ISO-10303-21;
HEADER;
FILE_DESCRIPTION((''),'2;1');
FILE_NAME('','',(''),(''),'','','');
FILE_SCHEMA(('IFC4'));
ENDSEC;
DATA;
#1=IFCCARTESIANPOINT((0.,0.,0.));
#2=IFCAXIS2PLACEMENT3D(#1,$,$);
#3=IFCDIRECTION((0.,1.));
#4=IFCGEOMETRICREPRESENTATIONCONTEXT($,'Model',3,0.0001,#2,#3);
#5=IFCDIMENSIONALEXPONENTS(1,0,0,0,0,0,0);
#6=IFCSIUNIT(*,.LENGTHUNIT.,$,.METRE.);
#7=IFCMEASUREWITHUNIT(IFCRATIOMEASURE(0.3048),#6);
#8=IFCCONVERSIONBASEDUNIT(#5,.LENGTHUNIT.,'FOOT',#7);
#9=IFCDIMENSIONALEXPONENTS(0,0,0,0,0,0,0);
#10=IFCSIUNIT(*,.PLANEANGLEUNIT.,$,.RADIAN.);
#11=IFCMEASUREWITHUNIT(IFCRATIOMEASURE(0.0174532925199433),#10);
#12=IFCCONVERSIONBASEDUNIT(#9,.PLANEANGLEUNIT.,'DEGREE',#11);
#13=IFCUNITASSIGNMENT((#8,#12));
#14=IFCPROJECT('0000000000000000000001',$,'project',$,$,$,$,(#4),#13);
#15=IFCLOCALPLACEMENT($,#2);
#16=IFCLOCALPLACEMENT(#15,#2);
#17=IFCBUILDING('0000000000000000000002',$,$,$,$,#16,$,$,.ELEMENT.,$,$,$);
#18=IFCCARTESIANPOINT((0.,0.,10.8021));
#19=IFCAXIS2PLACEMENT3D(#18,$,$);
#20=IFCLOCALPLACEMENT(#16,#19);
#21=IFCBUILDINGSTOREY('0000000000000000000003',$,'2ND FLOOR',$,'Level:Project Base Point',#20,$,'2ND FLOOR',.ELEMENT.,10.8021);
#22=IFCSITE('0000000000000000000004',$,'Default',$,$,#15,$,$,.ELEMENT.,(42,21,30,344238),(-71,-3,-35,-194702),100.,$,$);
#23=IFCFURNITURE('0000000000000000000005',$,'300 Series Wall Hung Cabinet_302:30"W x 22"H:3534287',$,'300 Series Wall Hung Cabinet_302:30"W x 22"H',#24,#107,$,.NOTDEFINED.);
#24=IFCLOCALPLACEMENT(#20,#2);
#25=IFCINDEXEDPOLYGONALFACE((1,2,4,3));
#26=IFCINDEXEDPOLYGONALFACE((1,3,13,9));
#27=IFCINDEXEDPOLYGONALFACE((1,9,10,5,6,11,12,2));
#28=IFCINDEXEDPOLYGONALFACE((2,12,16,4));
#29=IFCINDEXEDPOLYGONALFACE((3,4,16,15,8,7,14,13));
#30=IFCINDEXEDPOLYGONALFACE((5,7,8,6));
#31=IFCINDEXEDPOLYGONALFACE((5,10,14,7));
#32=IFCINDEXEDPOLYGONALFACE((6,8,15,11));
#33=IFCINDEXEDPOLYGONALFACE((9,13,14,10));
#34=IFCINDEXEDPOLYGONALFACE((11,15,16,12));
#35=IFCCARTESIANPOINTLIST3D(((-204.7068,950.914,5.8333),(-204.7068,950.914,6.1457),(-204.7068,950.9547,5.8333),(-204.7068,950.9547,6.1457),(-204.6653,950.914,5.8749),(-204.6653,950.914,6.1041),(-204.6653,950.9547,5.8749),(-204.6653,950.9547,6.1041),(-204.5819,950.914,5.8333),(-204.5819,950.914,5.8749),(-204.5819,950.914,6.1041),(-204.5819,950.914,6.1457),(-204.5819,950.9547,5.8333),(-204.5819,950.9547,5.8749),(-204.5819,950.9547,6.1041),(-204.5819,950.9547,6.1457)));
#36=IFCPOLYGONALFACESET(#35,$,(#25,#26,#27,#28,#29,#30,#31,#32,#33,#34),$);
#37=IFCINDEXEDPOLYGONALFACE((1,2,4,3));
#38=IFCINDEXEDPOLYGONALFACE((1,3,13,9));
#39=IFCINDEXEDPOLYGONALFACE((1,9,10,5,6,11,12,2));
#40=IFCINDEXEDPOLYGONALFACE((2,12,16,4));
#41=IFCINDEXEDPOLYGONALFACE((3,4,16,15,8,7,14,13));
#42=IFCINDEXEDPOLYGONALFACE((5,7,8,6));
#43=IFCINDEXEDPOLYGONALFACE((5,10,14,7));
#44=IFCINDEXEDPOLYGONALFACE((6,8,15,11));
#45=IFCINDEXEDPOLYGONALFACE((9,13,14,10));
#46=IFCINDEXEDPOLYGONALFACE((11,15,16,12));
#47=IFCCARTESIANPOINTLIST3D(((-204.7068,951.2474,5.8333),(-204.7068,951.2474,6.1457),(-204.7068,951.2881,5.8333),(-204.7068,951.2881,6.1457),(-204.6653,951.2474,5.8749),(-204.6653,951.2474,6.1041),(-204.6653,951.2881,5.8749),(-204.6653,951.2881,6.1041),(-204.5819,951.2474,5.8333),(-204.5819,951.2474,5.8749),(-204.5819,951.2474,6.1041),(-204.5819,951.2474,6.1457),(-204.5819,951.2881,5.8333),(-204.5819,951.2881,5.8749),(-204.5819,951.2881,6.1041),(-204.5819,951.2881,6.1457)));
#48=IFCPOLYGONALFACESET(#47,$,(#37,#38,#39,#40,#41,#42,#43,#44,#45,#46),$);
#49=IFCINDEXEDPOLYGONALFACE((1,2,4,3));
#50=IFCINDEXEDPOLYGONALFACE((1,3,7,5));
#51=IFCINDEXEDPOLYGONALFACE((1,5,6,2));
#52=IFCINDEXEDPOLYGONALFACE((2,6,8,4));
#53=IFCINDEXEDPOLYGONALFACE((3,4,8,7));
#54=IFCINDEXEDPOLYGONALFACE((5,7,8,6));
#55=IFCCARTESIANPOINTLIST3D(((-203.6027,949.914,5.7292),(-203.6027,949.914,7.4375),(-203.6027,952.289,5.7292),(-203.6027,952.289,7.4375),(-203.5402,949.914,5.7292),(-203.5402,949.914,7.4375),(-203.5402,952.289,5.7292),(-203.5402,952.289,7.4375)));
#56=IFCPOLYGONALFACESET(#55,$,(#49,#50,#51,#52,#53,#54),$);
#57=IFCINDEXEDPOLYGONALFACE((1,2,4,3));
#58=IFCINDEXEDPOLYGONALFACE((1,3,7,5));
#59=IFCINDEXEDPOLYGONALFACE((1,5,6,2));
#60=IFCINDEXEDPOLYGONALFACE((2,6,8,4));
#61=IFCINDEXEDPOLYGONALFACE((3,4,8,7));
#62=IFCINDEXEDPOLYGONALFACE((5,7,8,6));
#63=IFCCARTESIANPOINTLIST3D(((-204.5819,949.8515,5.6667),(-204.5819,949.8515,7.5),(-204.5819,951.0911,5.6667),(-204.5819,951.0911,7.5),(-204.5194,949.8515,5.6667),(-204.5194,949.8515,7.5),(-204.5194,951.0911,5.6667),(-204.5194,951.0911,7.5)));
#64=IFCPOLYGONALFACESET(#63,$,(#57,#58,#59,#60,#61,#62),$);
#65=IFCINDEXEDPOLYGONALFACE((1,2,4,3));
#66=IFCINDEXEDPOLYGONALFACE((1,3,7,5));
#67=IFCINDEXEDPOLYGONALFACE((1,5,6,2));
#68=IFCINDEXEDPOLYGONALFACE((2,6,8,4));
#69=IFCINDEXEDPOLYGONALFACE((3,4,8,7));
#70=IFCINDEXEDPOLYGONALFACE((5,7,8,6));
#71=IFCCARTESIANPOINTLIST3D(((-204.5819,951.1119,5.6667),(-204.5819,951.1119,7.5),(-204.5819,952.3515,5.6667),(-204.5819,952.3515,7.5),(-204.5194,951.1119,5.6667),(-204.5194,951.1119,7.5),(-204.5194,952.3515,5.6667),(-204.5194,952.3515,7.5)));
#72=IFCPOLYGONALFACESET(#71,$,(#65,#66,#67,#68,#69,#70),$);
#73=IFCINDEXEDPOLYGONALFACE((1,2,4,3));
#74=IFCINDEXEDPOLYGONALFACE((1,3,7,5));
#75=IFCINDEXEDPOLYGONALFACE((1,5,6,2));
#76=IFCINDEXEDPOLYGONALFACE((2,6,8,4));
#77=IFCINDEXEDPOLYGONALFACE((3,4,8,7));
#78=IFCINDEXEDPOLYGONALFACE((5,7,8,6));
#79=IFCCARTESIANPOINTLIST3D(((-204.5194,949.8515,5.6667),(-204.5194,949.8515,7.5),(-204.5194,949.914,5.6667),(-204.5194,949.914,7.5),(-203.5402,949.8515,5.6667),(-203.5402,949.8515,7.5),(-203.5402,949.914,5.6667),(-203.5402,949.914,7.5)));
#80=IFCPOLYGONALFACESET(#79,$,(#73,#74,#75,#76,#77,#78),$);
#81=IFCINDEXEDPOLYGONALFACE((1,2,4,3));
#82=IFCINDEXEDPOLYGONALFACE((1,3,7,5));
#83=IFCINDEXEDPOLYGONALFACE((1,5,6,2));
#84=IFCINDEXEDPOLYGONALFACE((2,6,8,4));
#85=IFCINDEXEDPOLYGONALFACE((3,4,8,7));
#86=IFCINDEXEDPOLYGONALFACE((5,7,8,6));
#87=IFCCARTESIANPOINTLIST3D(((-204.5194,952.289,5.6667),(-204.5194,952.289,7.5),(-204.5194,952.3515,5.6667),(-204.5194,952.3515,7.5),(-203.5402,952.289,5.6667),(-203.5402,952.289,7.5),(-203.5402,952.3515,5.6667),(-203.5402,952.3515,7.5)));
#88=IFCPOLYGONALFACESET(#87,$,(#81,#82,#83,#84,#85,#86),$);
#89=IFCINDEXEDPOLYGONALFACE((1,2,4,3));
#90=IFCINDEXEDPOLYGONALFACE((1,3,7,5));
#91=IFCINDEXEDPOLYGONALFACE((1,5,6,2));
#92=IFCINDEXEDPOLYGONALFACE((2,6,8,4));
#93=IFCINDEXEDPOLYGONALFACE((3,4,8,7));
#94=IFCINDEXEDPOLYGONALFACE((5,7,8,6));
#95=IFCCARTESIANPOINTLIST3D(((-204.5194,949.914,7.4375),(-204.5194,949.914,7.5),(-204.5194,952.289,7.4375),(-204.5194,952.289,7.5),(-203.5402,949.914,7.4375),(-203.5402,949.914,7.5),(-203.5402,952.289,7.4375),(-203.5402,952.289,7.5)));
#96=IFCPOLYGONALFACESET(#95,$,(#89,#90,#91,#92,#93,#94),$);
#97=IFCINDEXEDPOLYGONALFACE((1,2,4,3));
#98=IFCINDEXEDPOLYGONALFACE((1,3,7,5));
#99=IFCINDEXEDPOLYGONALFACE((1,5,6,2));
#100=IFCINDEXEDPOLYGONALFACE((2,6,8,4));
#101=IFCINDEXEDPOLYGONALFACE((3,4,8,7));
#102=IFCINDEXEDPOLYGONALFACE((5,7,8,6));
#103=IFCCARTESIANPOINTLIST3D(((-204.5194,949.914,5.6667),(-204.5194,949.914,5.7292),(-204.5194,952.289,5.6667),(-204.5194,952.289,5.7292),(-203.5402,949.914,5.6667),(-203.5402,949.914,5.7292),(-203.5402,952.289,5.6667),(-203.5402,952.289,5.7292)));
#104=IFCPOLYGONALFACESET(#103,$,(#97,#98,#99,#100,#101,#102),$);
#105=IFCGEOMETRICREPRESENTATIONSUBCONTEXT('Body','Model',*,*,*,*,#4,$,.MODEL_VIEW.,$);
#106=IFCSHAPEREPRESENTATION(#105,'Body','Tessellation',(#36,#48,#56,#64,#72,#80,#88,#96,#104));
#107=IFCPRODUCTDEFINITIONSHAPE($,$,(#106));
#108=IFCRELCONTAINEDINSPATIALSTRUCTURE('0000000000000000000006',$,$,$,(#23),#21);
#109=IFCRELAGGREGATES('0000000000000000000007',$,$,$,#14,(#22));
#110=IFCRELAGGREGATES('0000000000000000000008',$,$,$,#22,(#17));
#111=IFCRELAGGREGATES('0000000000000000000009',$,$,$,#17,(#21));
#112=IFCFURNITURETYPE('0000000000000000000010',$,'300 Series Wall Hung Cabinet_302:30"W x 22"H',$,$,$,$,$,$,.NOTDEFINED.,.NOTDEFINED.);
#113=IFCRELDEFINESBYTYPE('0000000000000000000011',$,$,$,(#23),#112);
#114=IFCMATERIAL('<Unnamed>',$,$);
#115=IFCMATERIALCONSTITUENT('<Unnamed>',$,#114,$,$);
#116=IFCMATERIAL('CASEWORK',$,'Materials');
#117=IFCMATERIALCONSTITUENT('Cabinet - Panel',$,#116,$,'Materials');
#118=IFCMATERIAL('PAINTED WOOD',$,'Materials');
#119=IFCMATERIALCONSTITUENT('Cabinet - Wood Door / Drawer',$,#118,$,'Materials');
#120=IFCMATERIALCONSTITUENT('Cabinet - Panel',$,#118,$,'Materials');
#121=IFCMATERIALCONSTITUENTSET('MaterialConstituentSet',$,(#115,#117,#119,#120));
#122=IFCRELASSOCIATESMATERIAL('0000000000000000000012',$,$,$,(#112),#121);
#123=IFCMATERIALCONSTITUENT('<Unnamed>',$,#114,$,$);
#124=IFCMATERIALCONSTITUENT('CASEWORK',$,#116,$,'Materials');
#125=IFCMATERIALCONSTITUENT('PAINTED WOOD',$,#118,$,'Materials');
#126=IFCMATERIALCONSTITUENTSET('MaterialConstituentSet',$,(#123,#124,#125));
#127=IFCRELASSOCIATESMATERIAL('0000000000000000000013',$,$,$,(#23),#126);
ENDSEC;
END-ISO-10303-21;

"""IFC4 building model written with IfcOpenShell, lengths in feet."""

from ifc_helpers import new_model, entity, si_unit, converted_unit, direction, frame, frame_2d, origin, origin_2d_with_axis, place, context, subcontext, project, spatial, polyline, rectangle, outline, extrude, source, transform, mapped, material, constituent, constituent_set, type_object, type_shapes, element, save


model = new_model("IFC4")

# Units and contexts
model_context = context("Model", 3, precision=0.0001, world=origin(), true_north=direction((0.0, 1.0)))
body_context = subcontext(model_context, "Body", "Model", "MODEL_VIEW")
ifc_project = project(units=[converted_unit("LENGTHUNIT", "FOOT", entity("IfcRatioMeasure", 0.3048), si_unit("LENGTHUNIT", "METRE"), dimensions=[1, 0, 0, 0, 0, 0, 0]), converted_unit("PLANEANGLEUNIT", "DEGREE", entity("IfcRatioMeasure", 0.0174532925199433), si_unit("PLANEANGLEUNIT", "RADIAN"), dimensions=[0, 0, 0, 0, 0, 0, 0])], contexts=[model_context])

# Site, building, storey
site_placement = place(None, origin())
site = spatial("IfcSite", under=ifc_project, at=site_placement, Name="Default", CompositionType="ELEMENT", RefLatitude=(42, 21, 30, 344238), RefLongitude=(-71, -3, -35, -194702), RefElevation=100.0)
building_placement = place(site_placement, origin())
building = spatial("IfcBuilding", under=site, at=building_placement, CompositionType="ELEMENT")
storey_placement = place(building_placement, frame((0.0, 0.0, 10.8021)))
storey = spatial("IfcBuildingStorey", under=building, at=storey_placement, Name="2ND FLOOR", ObjectType="Level:Project Base Point", LongName="2ND FLOOR", CompositionType="ELEMENT", Elevation=10.8021)

# Furniture
ifc_material_1 = material(Name="<Unnamed>")
ifc_constituent_1 = constituent(ifc_material_1, Name="<Unnamed>")
ifc_material_2 = material(Name="CASEWORK", Category="Materials")
ifc_constituent_2 = constituent(ifc_material_2, Name="CASEWORK", Category="Materials")
ifc_material_3 = material(Name="PAINTED WOOD", Category="Materials")
ifc_constituent_3 = constituent(ifc_material_3, Name="PAINTED WOOD", Category="Materials")
ifc_constituent_set_1 = constituent_set(constituents=[ifc_constituent_1, ifc_constituent_2, ifc_constituent_3], Name="MaterialConstituentSet")
ifc_constituent_4 = constituent(ifc_material_1, Name="<Unnamed>")
ifc_constituent_5 = constituent(ifc_material_2, Name="Cabinet - Panel", Category="Materials")
ifc_constituent_6 = constituent(ifc_material_3, Name="Cabinet - Wood Door / Drawer", Category="Materials")
ifc_constituent_7 = constituent(ifc_material_3, Name="Cabinet - Panel", Category="Materials")
ifc_constituent_set_2 = constituent_set(constituents=[ifc_constituent_4, ifc_constituent_5, ifc_constituent_6, ifc_constituent_7], Name="MaterialConstituentSet")
furniture_type_1 = type_object("IfcFurnitureType", Name="300 Series Wall Hung Cabinet_302:30\"W x 22\"H", AssemblyPlace="NOTDEFINED", PredefinedType="NOTDEFINED", material=ifc_constituent_set_2)
shared_shape_1 = source(origin(), body_context, "Body", "SweptSolid", [
    extrude(outline(polyline([(-0.0521, -0.1146), (-0.0521, -0.1562), (0.0729, -0.1562), (0.0729, 0.1562), (-0.0521, 0.1562), (-0.0521, 0.1146), (0.0313, 0.1146), (0.0313, -0.1146), (-0.0521, -0.1146)])), frame((1.0625, 1.0937, 0.3229), z_axis=(-1.0, 0.0, 0.0), x_axis=(0.0, 1.0, 0.0)), (0.0, 0.0, -1.0), 0.0407),
    extrude(outline(polyline([(-0.0521, -0.1146), (-0.0521, -0.1562), (0.0729, -0.1562), (0.0729, 0.1562), (-0.0521, 0.1562), (-0.0521, 0.1146), (0.0313, 0.1146), (0.0313, -0.1146), (-0.0521, -0.1146)])), frame((1.3958, 1.0937, 0.3229), z_axis=(-1.0, 0.0, 0.0), x_axis=(0.0, 1.0, 0.0)), (0.0, 0.0, -1.0), 0.0407),
    extrude(rectangle(XDim=0.0625, YDim=2.375, at=frame_2d((0.0, 0.0), x_axis=(1.0, 0.0))), frame((1.25, 0.0313, 0.0625), z_axis=(0.0, 0.0, 1.0), x_axis=(0.0, 1.0, 0.0)), (0.0, 0.0, 1.0), 1.7083),
    extrude(rectangle(XDim=0.0625, YDim=1.2396, at=origin_2d_with_axis()), frame((0.6198, 1.0104, 0.0), z_axis=(0.0, 0.0, 1.0), x_axis=(0.0, 1.0, 0.0)), (0.0, 0.0, 1.0), 1.8333),
    extrude(rectangle(XDim=0.0625, YDim=1.2396, at=frame_2d((0.0, 0.0), x_axis=(1.0, 0.0))), frame((1.8802, 1.0104, 0.0), z_axis=(0.0, 0.0, 1.0), x_axis=(0.0, 1.0, 0.0)), (0.0, 0.0, 1.0), 1.8333),
    extrude(rectangle(XDim=0.0625, YDim=0.9792, at=frame_2d((0.0, 0.0), x_axis=(1.0, 0.0))), frame((0.0313, 0.4896, 0.0)), (0.0, 0.0, 1.0), 1.8333),
    extrude(rectangle(XDim=0.0625, YDim=0.9792, at=frame_2d((0.0, 0.0), x_axis=(1.0, 0.0))), frame((2.4688, 0.4896, 0.0)), (0.0, 0.0, 1.0), 1.8333),
    extrude(rectangle(XDim=2.375, YDim=0.9792, at=frame_2d((0.0, 0.0), x_axis=(1.0, 0.0))), frame((1.25, 0.4896, 1.7708), z_axis=(0.0, 0.0, 1.0), x_axis=(-1.0, 0.0, 0.0)), (0.0, 0.0, 1.0), 0.0625),
    extrude(rectangle(XDim=2.375, YDim=0.9792, at=frame_2d((0.0, 0.0), x_axis=(1.0, 0.0))), frame((1.25, 0.4896, 0.0), z_axis=(0.0, 0.0, 1.0), x_axis=(-1.0, 0.0, 0.0)), (0.0, 0.0, 1.0), 0.0625),
])
type_shapes(furniture_type_1, [shared_shape_1])
furniture_1_placement = place(storey_placement, frame((-203.5402, 949.8515, 5.6667), z_axis=(0.0, 0.0, 1.0), x_axis=(0.0, 1.0, 0.0)))
element("IfcFurniture", 1, at=furniture_1_placement, inside=storey, type_object=furniture_type_1, material=ifc_constituent_set_1, Name="300 Series Wall Hung Cabinet_302:30\"W x 22\"H:3534287", ObjectType="300 Series Wall Hung Cabinet_302:30\"W x 22\"H", PredefinedType="NOTDEFINED", context=body_context, shape_type="MappedRepresentation", body=[
    mapped(shared_shape_1, transform((0.0, 0.0, 0.0), scale=1.0)),
])

save(model, "model.ifc")
